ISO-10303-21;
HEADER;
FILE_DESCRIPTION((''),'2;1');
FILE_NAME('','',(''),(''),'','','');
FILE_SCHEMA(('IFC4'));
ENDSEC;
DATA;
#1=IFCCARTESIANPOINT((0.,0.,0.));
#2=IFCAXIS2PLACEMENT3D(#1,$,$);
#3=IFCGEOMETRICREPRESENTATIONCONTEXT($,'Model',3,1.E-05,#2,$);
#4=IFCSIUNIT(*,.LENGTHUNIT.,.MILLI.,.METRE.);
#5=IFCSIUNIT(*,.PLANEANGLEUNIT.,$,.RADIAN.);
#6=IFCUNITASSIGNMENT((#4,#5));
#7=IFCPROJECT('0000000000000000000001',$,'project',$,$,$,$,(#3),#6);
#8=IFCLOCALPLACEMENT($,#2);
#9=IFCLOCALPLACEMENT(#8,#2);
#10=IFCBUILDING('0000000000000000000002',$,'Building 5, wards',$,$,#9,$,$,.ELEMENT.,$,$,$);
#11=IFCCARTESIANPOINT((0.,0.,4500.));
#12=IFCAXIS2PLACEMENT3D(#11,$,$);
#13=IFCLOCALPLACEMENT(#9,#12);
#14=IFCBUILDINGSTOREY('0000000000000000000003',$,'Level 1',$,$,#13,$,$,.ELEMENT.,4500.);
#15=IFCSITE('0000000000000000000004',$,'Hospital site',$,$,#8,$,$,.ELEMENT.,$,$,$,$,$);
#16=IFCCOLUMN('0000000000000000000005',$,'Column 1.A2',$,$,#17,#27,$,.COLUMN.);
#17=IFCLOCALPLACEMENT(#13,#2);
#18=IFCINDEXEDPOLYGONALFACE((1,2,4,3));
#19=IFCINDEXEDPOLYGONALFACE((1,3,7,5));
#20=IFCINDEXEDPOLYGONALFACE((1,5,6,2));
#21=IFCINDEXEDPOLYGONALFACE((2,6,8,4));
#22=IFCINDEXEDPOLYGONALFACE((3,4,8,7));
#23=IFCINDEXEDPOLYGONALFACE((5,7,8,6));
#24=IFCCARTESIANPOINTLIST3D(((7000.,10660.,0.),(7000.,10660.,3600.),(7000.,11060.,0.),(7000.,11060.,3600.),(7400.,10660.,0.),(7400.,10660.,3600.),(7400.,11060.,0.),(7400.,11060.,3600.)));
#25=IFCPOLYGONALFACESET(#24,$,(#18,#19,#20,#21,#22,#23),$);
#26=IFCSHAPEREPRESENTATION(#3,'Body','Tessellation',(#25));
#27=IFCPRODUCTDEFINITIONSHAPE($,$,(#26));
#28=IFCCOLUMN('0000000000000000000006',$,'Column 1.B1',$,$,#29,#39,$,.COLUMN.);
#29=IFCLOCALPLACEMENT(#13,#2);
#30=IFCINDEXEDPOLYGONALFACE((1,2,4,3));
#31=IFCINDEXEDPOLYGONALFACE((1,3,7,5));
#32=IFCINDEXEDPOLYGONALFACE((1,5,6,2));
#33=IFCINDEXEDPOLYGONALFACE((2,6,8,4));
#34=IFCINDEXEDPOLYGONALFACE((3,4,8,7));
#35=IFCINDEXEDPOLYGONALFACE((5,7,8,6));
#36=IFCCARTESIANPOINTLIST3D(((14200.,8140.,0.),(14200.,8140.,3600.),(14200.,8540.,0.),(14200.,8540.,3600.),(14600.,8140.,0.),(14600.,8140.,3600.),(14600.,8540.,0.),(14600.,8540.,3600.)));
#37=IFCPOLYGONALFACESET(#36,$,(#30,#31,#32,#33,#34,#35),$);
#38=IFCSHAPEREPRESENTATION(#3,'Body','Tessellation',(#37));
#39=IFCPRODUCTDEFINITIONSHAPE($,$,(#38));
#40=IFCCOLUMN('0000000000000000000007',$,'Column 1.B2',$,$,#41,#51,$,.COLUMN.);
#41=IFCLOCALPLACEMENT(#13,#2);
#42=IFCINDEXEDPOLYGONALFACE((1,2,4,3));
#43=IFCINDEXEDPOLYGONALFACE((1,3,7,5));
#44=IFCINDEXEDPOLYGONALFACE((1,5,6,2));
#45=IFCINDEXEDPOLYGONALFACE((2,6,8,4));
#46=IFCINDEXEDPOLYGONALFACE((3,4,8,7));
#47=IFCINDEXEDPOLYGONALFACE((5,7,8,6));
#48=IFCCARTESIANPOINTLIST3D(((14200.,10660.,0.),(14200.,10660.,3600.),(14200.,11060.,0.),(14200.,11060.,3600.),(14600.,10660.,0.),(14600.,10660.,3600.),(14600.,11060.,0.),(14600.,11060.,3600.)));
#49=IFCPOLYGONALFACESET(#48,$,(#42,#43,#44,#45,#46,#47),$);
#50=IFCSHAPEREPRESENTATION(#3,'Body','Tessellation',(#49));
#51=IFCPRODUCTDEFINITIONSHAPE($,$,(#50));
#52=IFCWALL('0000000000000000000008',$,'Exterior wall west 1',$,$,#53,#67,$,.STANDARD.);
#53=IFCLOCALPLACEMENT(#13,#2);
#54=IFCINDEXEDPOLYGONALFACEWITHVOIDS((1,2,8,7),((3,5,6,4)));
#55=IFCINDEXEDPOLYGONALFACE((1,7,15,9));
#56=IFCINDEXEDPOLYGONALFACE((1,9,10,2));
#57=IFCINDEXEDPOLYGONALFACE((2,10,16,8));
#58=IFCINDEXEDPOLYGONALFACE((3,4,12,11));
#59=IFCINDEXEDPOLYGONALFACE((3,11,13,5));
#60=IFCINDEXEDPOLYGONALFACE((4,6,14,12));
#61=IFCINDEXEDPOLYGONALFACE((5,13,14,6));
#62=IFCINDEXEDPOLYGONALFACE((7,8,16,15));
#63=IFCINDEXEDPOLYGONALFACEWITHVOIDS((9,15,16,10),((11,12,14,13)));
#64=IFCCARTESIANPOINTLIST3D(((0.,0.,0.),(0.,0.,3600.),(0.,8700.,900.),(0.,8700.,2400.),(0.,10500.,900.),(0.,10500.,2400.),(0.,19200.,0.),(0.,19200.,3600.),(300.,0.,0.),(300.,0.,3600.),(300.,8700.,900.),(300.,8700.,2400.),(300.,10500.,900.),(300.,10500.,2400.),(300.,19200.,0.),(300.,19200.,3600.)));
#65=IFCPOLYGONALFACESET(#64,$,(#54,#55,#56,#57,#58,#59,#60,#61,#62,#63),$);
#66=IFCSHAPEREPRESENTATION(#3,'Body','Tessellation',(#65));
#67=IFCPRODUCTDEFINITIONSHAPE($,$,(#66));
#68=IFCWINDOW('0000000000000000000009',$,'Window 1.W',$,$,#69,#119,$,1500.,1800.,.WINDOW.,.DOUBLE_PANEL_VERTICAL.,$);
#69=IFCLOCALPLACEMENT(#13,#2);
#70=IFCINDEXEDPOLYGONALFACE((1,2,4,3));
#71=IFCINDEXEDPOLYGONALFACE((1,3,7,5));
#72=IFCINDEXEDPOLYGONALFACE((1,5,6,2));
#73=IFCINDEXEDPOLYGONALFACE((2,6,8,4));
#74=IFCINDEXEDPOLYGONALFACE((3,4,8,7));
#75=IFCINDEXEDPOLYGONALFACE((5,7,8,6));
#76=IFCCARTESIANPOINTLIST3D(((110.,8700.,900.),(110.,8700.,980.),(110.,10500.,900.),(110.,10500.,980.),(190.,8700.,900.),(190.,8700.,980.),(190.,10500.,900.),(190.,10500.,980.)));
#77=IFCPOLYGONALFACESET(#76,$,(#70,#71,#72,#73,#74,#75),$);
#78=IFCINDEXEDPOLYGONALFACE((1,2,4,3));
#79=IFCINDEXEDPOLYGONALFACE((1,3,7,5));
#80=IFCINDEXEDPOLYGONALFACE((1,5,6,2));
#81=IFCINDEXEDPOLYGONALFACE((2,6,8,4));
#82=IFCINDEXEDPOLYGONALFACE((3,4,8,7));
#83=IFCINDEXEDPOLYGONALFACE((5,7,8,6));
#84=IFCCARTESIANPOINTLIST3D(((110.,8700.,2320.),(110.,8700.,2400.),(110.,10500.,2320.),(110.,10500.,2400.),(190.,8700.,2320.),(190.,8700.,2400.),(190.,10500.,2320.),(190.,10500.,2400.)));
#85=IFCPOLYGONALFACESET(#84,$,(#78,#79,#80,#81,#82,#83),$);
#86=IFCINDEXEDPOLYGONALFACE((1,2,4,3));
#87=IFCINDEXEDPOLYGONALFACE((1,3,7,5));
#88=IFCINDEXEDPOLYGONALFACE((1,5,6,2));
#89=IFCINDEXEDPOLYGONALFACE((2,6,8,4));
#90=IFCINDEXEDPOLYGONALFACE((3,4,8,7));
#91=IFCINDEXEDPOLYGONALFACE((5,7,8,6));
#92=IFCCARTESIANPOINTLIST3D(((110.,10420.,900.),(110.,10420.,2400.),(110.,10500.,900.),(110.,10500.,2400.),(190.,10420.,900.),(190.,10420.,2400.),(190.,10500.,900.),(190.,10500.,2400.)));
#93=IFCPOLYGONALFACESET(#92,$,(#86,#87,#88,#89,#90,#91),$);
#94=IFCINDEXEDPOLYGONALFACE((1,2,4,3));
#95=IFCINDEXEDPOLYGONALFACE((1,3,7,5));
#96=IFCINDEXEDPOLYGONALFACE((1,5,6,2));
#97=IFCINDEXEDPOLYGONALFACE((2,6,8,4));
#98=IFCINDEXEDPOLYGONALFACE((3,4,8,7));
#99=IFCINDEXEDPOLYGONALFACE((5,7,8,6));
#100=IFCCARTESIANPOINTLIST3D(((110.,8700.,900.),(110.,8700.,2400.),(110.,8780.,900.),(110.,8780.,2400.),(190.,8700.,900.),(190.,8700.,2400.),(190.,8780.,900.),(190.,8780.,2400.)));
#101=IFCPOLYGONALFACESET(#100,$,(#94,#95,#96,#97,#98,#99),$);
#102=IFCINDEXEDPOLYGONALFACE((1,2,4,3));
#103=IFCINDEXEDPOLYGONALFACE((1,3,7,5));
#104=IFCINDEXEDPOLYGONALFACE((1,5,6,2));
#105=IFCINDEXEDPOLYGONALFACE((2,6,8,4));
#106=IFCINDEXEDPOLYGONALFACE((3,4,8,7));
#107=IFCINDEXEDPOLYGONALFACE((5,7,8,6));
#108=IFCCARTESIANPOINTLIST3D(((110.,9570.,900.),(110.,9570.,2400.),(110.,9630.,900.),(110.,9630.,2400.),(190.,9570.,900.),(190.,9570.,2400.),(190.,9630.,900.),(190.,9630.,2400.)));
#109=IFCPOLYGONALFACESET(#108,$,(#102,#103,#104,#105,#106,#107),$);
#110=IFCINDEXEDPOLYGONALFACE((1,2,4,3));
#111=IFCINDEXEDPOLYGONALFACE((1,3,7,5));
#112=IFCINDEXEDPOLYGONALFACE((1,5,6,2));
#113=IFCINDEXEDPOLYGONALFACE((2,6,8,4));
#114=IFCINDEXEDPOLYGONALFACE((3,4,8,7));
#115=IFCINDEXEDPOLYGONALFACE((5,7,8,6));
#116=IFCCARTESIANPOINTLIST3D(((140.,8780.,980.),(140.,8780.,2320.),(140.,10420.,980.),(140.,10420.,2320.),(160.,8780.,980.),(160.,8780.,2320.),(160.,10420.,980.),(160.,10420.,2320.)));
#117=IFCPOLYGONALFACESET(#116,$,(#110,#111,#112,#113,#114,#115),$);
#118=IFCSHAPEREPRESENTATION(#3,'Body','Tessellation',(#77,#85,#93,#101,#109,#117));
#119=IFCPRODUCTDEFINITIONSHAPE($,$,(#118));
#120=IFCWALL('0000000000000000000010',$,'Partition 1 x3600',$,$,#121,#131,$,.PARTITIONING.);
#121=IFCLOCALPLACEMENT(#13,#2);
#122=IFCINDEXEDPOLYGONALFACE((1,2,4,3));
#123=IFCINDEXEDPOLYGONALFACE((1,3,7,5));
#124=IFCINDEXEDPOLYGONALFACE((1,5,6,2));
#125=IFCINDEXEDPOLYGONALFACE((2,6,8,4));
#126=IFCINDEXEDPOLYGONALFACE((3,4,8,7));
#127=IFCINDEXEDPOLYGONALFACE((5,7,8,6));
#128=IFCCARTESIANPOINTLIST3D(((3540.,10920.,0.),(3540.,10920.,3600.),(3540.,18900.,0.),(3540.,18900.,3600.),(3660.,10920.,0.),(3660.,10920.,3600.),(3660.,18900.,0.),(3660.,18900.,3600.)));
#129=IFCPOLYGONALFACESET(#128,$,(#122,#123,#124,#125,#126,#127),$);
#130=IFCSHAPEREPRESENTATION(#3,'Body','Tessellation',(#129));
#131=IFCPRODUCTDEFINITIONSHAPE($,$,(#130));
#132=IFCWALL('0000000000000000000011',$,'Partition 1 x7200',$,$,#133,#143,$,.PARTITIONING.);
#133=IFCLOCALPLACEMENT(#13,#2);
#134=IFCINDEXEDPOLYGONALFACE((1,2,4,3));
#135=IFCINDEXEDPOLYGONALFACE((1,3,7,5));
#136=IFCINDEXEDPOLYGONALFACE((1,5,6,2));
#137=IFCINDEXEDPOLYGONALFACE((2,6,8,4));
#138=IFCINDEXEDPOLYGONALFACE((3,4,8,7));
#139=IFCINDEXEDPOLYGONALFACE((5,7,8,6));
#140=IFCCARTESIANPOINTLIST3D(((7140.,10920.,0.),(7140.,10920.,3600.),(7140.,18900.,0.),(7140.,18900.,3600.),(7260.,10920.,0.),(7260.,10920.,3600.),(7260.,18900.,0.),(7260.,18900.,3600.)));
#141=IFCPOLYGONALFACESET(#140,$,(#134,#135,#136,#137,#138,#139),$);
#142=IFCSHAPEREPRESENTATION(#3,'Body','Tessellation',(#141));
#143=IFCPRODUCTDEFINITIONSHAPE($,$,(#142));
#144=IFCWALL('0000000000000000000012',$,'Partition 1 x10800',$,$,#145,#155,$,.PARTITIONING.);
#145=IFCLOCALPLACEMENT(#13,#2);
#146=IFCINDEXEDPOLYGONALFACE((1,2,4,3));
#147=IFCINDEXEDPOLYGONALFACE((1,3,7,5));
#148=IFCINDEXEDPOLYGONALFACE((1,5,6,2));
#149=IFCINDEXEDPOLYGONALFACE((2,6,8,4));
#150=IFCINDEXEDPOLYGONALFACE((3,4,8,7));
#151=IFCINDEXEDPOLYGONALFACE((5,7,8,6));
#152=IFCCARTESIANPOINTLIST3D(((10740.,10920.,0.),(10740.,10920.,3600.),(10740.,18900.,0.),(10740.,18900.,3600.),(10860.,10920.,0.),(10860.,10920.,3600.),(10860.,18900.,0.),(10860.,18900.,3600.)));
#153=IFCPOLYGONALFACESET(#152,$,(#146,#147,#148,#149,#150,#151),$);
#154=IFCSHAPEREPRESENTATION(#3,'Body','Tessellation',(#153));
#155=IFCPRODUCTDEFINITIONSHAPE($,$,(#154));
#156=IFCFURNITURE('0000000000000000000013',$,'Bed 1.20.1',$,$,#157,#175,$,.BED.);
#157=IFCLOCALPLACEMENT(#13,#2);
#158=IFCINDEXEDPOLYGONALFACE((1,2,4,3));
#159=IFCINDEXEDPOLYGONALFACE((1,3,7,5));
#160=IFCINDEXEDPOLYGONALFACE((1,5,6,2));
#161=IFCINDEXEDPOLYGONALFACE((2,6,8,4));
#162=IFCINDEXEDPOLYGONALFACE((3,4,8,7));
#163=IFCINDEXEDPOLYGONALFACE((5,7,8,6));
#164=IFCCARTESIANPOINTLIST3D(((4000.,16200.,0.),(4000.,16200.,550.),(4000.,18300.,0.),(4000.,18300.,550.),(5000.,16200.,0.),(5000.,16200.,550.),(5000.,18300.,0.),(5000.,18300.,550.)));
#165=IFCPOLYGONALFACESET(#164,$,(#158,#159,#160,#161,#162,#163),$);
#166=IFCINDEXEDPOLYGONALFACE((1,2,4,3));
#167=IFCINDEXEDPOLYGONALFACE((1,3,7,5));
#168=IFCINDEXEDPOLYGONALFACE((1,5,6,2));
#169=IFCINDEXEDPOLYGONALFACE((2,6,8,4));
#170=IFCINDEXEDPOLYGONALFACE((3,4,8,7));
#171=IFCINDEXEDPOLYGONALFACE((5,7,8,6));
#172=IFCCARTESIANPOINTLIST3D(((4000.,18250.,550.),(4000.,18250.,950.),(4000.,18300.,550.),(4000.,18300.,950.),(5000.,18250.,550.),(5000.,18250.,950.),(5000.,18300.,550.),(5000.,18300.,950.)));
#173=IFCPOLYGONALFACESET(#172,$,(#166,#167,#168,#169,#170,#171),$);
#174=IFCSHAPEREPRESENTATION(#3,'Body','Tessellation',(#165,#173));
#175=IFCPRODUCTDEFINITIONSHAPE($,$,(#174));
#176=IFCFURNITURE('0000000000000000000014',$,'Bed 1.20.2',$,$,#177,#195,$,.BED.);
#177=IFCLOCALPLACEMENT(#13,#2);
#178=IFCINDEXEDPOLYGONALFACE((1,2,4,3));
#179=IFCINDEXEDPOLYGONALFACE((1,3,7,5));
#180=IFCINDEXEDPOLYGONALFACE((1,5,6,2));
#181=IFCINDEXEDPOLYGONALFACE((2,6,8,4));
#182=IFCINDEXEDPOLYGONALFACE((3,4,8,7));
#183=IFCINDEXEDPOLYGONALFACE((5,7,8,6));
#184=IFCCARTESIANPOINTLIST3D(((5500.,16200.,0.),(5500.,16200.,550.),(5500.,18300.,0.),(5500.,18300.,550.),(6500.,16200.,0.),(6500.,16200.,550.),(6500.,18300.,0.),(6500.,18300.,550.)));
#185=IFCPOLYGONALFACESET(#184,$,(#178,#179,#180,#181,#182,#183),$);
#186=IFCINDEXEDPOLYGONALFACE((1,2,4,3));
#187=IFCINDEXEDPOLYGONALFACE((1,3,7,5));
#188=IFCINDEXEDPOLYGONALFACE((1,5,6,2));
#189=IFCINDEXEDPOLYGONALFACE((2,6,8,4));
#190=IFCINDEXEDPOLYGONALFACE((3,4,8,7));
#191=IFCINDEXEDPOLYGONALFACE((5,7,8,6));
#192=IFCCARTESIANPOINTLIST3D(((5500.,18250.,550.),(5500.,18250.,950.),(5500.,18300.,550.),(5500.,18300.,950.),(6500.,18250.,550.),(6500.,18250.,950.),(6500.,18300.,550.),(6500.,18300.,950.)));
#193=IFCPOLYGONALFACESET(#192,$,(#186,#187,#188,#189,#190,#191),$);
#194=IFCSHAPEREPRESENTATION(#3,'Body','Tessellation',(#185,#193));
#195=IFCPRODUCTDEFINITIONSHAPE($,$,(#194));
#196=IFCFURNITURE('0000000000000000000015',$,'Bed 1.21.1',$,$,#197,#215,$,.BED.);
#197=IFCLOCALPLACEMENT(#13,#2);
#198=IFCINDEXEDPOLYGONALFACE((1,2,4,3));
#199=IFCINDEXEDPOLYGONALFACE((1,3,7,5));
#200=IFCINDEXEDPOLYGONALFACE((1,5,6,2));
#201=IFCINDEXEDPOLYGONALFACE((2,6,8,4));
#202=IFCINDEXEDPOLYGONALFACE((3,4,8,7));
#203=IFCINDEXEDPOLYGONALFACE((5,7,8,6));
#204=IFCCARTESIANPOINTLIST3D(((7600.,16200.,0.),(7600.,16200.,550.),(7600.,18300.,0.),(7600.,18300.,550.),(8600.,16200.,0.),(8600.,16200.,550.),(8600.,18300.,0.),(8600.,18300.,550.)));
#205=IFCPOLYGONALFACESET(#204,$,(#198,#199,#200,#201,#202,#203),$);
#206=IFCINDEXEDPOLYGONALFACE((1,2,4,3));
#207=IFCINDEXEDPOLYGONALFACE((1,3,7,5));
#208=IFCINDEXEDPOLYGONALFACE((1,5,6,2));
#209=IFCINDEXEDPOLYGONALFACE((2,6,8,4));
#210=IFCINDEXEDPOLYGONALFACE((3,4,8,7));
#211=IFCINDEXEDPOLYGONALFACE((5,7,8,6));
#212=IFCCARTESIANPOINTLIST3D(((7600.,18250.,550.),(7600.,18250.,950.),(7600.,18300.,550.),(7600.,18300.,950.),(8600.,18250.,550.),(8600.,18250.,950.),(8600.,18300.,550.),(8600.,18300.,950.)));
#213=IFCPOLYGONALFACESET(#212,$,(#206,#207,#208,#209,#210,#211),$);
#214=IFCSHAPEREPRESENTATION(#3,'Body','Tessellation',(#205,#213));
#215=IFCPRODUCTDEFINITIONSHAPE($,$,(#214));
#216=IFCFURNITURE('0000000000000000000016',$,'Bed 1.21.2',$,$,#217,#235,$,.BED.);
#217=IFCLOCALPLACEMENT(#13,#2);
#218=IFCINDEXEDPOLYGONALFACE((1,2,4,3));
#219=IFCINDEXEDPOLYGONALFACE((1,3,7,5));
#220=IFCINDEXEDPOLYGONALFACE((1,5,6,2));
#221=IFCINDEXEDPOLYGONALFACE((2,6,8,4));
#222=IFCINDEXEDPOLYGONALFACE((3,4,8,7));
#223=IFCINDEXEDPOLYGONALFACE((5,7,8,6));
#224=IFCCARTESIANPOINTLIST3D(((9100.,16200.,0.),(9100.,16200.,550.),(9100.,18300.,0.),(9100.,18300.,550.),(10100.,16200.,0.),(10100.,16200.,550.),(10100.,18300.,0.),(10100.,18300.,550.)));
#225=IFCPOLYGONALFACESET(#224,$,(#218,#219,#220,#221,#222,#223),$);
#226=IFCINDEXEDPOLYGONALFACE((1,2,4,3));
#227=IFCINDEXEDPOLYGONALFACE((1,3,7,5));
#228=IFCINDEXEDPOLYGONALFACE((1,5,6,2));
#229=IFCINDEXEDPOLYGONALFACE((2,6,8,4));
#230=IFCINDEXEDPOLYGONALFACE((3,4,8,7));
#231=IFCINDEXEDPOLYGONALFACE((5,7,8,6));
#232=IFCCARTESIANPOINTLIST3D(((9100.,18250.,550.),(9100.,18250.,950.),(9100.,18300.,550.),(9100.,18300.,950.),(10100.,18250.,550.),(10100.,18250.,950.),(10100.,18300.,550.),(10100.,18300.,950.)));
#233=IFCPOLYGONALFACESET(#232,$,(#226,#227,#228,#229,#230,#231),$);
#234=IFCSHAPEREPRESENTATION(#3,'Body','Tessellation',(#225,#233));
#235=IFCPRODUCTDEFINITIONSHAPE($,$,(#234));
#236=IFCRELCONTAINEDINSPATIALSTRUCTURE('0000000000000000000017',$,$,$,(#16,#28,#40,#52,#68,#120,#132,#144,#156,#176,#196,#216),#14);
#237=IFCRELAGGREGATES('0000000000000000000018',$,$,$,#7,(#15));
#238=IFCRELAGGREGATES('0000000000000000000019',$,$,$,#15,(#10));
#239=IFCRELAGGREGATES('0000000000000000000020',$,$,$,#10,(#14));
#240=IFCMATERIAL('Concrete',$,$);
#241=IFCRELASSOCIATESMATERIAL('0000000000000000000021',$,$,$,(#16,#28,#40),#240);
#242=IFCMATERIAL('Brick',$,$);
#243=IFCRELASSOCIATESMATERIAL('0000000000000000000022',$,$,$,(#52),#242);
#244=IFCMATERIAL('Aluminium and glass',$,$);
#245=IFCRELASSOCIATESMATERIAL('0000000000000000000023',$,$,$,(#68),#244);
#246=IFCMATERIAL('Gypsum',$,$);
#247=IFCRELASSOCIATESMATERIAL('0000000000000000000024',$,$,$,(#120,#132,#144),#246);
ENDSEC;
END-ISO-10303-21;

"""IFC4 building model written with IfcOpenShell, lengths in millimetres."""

from ifc_helpers import new_model, si_unit, frame, frame_2d, origin, origin_2d, place, context, project, spatial, rectangle, extrude, material, element, fill, save


model = new_model("IFC4")

# Units and contexts
model_context = context("Model", 3, precision=1e-05, world=origin())
ifc_project = project(units=[si_unit("LENGTHUNIT", "METRE", prefix="MILLI"), si_unit("PLANEANGLEUNIT", "RADIAN")], contexts=[model_context])

# Site, building, storey
site_placement = place(None, origin())
site = spatial("IfcSite", under=ifc_project, at=site_placement, Name="Hospital site", CompositionType="ELEMENT")
building_placement = place(site_placement, origin())
building = spatial("IfcBuilding", under=site, at=building_placement, Name="Building 5, wards", CompositionType="ELEMENT")
storey_placement = place(building_placement, frame((0.0, 0.0, 4500.0)))
storey = spatial("IfcBuildingStorey", under=building, at=storey_placement, Name="Level 1", CompositionType="ELEMENT", Elevation=4500.0)

# Columns
ifc_material_1 = material(Name="Concrete")
for number, where, name in (
    (1, (7200.0, 10860.0, 0.0), "Column 1.A2"),
    (2, (14400.0, 8340.0, 0.0), "Column 1.B1"),
    (3, (14400.0, 10860.0, 0.0), "Column 1.B2"),
):
    element("IfcColumn", number, at=place(storey_placement, frame(where)), inside=storey, material=ifc_material_1, Name=name, PredefinedType="COLUMN", context=model_context, shape_type="SweptSolid", body=[
        extrude(rectangle(XDim=400.0, YDim=400.0, at=origin_2d()), origin(), (0.0, 0.0, 1.0), 3600.0),
    ])

# Wall, opening, window
ifc_material_2 = material(Name="Brick")
wall_placement = place(storey_placement, frame((0.0, 19200.0, 0.0), x_axis=(0.0, -1.0, 0.0)))
wall = element("IfcWall", 4, at=wall_placement, inside=storey, material=ifc_material_2, Name="Exterior wall west 1", PredefinedType="STANDARD", context=model_context, shape_type="SweptSolid", body=[
    extrude(rectangle(XDim=19200.0, YDim=300.0, at=frame_2d((9600.0, 150.0))), origin(), (0.0, 0.0, 1.0), 3600.0),
])
opening_placement = place(wall_placement, frame((8700.0, -50.0, 900.0)))
opening = element("IfcOpeningElement", 5, at=opening_placement, cuts=wall, PredefinedType="OPENING", context=model_context, shape_type="SweptSolid", body=[
    extrude(rectangle(XDim=1800.0, YDim=400.0, at=frame_2d((900.0, 200.0))), origin(), (0.0, 0.0, 1.0), 1500.0),
])
ifc_material_3 = material(Name="Aluminium and glass")
window_placement = place(opening_placement, frame((0.0, 160.0, 0.0)))
window = element("IfcWindow", 6, at=window_placement, inside=storey, material=ifc_material_3, Name="Window 1.W", OverallHeight=1500.0, OverallWidth=1800.0, PartitioningType="DOUBLE_PANEL_VERTICAL", PredefinedType="WINDOW", context=model_context, shape_type="SweptSolid", body=[
    extrude(rectangle(XDim=1800.0, YDim=80.0, at=frame_2d((900.0, 40.0))), origin(), (0.0, 0.0, 1.0), 80.0),
    extrude(rectangle(XDim=1800.0, YDim=80.0, at=frame_2d((900.0, 40.0))), frame((0.0, 0.0, 1420.0)), (0.0, 0.0, 1.0), 80.0),
    extrude(rectangle(XDim=80.0, YDim=80.0, at=frame_2d((40.0, 40.0))), origin(), (0.0, 0.0, 1.0), 1500.0),
    extrude(rectangle(XDim=80.0, YDim=80.0, at=frame_2d((1760.0, 40.0))), origin(), (0.0, 0.0, 1.0), 1500.0),
    extrude(rectangle(XDim=60.0, YDim=80.0, at=frame_2d((900.0, 40.0))), origin(), (0.0, 0.0, 1.0), 1500.0),
    extrude(rectangle(XDim=1640.0, YDim=20.0, at=frame_2d((900.0, 40.0))), frame((0.0, 0.0, 80.0)), (0.0, 0.0, 1.0), 1340.0),
])
fill(opening, window)

# Walls
ifc_material_4 = material(Name="Gypsum")
for number, where, x_axis, name in (
    (7, (3660.0, 10920.0, 0.0), (0.0, 1.0, 0.0), "Partition 1 x3600"),
    (8, (7260.0, 10920.0, 0.0), (0.0, 1.0, 0.0), "Partition 1 x7200"),
    (9, (10860.0, 10920.0, 0.0), (0.0, 1.0, 0.0), "Partition 1 x10800"),
):
    element("IfcWall", number, at=place(storey_placement, frame(where, x_axis=x_axis)), inside=storey, material=ifc_material_4, Name=name, PredefinedType="PARTITIONING", context=model_context, shape_type="SweptSolid", body=[
        extrude(rectangle(XDim=7980.0, YDim=120.0, at=frame_2d((3990.0, 60.0))), origin(), (0.0, 0.0, 1.0), 3600.0),
    ])

# Furniture
for number, where, name in (
    (10, (4000.0, 16200.0, 0.0), "Bed 1.20.1"),
    (11, (5500.0, 16200.0, 0.0), "Bed 1.20.2"),
    (12, (7600.0, 16200.0, 0.0), "Bed 1.21.1"),
    (13, (9100.0, 16200.0, 0.0), "Bed 1.21.2"),
):
    element("IfcFurniture", number, at=place(storey_placement, frame(where)), inside=storey, Name=name, PredefinedType="BED", context=model_context, shape_type="SweptSolid", body=[
        extrude(rectangle(XDim=1000.0, YDim=2100.0, at=frame_2d((500.0, 1050.0))), origin(), (0.0, 0.0, 1.0), 550.0),
        extrude(rectangle(XDim=1000.0, YDim=50.0, at=frame_2d((500.0, 2075.0))), frame((0.0, 0.0, 550.0)), (0.0, 0.0, 1.0), 400.0),
    ])

save(model, "model.ifc")
